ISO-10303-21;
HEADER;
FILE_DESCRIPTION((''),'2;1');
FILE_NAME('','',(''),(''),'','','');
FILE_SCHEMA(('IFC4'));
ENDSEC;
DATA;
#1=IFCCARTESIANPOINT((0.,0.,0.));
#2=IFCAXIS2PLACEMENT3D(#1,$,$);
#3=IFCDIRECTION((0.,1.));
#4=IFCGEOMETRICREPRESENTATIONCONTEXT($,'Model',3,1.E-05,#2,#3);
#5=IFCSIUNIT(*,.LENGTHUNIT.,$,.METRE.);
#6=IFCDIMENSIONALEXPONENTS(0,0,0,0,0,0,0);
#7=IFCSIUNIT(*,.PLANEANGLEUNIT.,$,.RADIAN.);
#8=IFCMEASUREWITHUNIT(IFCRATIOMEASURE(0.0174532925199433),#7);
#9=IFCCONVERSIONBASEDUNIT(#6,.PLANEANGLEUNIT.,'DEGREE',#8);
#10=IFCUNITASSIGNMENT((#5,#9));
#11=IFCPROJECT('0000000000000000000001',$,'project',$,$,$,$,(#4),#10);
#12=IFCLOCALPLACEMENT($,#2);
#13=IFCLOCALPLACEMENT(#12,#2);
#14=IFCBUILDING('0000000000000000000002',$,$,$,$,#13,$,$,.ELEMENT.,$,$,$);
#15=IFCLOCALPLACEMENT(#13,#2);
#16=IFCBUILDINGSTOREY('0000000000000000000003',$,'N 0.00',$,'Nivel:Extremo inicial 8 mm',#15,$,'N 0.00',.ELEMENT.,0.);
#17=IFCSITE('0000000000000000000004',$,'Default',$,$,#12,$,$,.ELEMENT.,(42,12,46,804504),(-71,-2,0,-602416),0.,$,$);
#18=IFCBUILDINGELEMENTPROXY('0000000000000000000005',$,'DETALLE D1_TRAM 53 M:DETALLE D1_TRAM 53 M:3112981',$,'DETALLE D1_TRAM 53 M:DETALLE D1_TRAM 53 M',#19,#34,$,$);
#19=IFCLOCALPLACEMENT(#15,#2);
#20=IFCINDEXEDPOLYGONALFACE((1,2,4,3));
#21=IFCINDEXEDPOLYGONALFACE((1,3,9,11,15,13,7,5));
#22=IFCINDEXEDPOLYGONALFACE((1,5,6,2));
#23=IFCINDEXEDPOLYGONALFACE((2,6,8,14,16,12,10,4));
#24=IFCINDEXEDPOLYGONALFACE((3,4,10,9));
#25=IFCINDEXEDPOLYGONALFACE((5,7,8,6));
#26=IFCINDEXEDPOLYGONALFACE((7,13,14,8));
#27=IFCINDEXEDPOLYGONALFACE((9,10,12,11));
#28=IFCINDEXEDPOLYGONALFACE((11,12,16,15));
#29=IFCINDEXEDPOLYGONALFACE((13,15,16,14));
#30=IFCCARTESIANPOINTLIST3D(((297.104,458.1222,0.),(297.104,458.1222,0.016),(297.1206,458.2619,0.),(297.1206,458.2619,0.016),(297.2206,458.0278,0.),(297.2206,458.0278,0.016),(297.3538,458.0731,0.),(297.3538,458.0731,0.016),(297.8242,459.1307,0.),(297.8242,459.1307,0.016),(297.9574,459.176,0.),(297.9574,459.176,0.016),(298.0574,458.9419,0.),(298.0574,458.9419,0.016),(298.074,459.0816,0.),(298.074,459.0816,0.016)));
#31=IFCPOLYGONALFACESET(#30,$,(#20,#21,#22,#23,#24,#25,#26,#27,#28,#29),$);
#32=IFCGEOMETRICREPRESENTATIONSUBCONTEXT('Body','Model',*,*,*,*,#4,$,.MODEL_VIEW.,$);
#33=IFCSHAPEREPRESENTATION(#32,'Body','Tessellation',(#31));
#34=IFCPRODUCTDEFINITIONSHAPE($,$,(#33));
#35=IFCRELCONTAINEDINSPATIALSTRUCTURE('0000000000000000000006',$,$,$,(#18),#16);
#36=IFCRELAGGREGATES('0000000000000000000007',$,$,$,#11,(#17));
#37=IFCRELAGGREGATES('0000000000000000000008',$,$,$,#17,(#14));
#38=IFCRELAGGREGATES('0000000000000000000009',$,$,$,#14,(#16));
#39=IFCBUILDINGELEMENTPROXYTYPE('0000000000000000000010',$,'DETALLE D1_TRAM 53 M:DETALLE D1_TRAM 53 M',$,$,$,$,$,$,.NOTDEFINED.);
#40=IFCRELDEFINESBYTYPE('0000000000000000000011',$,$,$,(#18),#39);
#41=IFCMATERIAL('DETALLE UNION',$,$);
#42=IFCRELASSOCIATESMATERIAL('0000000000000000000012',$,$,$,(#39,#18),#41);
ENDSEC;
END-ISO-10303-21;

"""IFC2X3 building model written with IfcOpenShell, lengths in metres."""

from ifc_helpers import new_model, entity, si_unit, converted_unit, direction, frame, origin, place, context, subcontext, project, spatial, polyline, outline, extrude, source, transform, mapped, material, type_object, type_shapes, element, save


model = new_model("IFC2X3")

# Units and contexts
model_context = context("Model", 3, precision=1e-05, world=origin(), true_north=direction((0.0, 1.0)))
body_context = subcontext(model_context, "Body", "Model", "MODEL_VIEW")
ifc_project = project(units=[si_unit("LENGTHUNIT", "METRE"), converted_unit("PLANEANGLEUNIT", "DEGREE", entity("IfcRatioMeasure", 0.0174532925199433), si_unit("PLANEANGLEUNIT", "RADIAN"), dimensions=[0, 0, 0, 0, 0, 0, 0])], contexts=[model_context])

# Site, building, storey
site_placement = place(None, origin())
site = spatial("IfcSite", under=ifc_project, at=site_placement, Name="Default", CompositionType="ELEMENT", RefLatitude=(42, 12, 46, 804504), RefLongitude=(-71, -2, 0, -602416), RefElevation=0.0)
building_placement = place(site_placement, origin())
building = spatial("IfcBuilding", under=site, at=building_placement, CompositionType="ELEMENT")
storey_placement = place(building_placement, origin())
storey = spatial("IfcBuildingStorey", under=building, at=storey_placement, Name="N 0.00", ObjectType="Nivel:Extremo inicial 8 mm", LongName="N 0.00", CompositionType="ELEMENT", Elevation=0.0)

# Building element proxy
ifc_material_1 = material(Name="DETALLE UNION")
building_element_proxy_type_1 = type_object("IfcBuildingElementProxyType", Name="DETALLE D1_TRAM 53 M:DETALLE D1_TRAM 53 M", PredefinedType="NOTDEFINED", material=ifc_material_1)
shared_shape_1 = source(origin(), body_context, "Body", "SweptSolid", [
    extrude(outline(polyline([(-0.075, -0.678), (0.075, -0.678), (0.15, -0.559), (0.15, 0.559), (0.075, 0.678), (-0.075, 0.678), (-0.15, 0.559), (-0.15, -0.559), (-0.075, -0.678)])), frame((0.0, 0.0, 0.0), z_axis=(0.0, 0.0, 1.0), x_axis=(-0.777146, 0.62932, 0.0)), (0.0, 0.0, 1.0), 0.016),
])
type_shapes(building_element_proxy_type_1, [shared_shape_1])
proxy_1_placement = place(storey_placement, frame((297.589, 458.6019, 0.0)))
element("IfcBuildingElementProxy", 1, at=proxy_1_placement, inside=storey, type_object=building_element_proxy_type_1, material=ifc_material_1, Name="DETALLE D1_TRAM 53 M:DETALLE D1_TRAM 53 M:3112981", ObjectType="DETALLE D1_TRAM 53 M:DETALLE D1_TRAM 53 M", context=body_context, shape_type="MappedRepresentation", body=[
    mapped(shared_shape_1, transform((0.0, 0.0, 0.0), scale=1.0)),
])

save(model, "model.ifc")
